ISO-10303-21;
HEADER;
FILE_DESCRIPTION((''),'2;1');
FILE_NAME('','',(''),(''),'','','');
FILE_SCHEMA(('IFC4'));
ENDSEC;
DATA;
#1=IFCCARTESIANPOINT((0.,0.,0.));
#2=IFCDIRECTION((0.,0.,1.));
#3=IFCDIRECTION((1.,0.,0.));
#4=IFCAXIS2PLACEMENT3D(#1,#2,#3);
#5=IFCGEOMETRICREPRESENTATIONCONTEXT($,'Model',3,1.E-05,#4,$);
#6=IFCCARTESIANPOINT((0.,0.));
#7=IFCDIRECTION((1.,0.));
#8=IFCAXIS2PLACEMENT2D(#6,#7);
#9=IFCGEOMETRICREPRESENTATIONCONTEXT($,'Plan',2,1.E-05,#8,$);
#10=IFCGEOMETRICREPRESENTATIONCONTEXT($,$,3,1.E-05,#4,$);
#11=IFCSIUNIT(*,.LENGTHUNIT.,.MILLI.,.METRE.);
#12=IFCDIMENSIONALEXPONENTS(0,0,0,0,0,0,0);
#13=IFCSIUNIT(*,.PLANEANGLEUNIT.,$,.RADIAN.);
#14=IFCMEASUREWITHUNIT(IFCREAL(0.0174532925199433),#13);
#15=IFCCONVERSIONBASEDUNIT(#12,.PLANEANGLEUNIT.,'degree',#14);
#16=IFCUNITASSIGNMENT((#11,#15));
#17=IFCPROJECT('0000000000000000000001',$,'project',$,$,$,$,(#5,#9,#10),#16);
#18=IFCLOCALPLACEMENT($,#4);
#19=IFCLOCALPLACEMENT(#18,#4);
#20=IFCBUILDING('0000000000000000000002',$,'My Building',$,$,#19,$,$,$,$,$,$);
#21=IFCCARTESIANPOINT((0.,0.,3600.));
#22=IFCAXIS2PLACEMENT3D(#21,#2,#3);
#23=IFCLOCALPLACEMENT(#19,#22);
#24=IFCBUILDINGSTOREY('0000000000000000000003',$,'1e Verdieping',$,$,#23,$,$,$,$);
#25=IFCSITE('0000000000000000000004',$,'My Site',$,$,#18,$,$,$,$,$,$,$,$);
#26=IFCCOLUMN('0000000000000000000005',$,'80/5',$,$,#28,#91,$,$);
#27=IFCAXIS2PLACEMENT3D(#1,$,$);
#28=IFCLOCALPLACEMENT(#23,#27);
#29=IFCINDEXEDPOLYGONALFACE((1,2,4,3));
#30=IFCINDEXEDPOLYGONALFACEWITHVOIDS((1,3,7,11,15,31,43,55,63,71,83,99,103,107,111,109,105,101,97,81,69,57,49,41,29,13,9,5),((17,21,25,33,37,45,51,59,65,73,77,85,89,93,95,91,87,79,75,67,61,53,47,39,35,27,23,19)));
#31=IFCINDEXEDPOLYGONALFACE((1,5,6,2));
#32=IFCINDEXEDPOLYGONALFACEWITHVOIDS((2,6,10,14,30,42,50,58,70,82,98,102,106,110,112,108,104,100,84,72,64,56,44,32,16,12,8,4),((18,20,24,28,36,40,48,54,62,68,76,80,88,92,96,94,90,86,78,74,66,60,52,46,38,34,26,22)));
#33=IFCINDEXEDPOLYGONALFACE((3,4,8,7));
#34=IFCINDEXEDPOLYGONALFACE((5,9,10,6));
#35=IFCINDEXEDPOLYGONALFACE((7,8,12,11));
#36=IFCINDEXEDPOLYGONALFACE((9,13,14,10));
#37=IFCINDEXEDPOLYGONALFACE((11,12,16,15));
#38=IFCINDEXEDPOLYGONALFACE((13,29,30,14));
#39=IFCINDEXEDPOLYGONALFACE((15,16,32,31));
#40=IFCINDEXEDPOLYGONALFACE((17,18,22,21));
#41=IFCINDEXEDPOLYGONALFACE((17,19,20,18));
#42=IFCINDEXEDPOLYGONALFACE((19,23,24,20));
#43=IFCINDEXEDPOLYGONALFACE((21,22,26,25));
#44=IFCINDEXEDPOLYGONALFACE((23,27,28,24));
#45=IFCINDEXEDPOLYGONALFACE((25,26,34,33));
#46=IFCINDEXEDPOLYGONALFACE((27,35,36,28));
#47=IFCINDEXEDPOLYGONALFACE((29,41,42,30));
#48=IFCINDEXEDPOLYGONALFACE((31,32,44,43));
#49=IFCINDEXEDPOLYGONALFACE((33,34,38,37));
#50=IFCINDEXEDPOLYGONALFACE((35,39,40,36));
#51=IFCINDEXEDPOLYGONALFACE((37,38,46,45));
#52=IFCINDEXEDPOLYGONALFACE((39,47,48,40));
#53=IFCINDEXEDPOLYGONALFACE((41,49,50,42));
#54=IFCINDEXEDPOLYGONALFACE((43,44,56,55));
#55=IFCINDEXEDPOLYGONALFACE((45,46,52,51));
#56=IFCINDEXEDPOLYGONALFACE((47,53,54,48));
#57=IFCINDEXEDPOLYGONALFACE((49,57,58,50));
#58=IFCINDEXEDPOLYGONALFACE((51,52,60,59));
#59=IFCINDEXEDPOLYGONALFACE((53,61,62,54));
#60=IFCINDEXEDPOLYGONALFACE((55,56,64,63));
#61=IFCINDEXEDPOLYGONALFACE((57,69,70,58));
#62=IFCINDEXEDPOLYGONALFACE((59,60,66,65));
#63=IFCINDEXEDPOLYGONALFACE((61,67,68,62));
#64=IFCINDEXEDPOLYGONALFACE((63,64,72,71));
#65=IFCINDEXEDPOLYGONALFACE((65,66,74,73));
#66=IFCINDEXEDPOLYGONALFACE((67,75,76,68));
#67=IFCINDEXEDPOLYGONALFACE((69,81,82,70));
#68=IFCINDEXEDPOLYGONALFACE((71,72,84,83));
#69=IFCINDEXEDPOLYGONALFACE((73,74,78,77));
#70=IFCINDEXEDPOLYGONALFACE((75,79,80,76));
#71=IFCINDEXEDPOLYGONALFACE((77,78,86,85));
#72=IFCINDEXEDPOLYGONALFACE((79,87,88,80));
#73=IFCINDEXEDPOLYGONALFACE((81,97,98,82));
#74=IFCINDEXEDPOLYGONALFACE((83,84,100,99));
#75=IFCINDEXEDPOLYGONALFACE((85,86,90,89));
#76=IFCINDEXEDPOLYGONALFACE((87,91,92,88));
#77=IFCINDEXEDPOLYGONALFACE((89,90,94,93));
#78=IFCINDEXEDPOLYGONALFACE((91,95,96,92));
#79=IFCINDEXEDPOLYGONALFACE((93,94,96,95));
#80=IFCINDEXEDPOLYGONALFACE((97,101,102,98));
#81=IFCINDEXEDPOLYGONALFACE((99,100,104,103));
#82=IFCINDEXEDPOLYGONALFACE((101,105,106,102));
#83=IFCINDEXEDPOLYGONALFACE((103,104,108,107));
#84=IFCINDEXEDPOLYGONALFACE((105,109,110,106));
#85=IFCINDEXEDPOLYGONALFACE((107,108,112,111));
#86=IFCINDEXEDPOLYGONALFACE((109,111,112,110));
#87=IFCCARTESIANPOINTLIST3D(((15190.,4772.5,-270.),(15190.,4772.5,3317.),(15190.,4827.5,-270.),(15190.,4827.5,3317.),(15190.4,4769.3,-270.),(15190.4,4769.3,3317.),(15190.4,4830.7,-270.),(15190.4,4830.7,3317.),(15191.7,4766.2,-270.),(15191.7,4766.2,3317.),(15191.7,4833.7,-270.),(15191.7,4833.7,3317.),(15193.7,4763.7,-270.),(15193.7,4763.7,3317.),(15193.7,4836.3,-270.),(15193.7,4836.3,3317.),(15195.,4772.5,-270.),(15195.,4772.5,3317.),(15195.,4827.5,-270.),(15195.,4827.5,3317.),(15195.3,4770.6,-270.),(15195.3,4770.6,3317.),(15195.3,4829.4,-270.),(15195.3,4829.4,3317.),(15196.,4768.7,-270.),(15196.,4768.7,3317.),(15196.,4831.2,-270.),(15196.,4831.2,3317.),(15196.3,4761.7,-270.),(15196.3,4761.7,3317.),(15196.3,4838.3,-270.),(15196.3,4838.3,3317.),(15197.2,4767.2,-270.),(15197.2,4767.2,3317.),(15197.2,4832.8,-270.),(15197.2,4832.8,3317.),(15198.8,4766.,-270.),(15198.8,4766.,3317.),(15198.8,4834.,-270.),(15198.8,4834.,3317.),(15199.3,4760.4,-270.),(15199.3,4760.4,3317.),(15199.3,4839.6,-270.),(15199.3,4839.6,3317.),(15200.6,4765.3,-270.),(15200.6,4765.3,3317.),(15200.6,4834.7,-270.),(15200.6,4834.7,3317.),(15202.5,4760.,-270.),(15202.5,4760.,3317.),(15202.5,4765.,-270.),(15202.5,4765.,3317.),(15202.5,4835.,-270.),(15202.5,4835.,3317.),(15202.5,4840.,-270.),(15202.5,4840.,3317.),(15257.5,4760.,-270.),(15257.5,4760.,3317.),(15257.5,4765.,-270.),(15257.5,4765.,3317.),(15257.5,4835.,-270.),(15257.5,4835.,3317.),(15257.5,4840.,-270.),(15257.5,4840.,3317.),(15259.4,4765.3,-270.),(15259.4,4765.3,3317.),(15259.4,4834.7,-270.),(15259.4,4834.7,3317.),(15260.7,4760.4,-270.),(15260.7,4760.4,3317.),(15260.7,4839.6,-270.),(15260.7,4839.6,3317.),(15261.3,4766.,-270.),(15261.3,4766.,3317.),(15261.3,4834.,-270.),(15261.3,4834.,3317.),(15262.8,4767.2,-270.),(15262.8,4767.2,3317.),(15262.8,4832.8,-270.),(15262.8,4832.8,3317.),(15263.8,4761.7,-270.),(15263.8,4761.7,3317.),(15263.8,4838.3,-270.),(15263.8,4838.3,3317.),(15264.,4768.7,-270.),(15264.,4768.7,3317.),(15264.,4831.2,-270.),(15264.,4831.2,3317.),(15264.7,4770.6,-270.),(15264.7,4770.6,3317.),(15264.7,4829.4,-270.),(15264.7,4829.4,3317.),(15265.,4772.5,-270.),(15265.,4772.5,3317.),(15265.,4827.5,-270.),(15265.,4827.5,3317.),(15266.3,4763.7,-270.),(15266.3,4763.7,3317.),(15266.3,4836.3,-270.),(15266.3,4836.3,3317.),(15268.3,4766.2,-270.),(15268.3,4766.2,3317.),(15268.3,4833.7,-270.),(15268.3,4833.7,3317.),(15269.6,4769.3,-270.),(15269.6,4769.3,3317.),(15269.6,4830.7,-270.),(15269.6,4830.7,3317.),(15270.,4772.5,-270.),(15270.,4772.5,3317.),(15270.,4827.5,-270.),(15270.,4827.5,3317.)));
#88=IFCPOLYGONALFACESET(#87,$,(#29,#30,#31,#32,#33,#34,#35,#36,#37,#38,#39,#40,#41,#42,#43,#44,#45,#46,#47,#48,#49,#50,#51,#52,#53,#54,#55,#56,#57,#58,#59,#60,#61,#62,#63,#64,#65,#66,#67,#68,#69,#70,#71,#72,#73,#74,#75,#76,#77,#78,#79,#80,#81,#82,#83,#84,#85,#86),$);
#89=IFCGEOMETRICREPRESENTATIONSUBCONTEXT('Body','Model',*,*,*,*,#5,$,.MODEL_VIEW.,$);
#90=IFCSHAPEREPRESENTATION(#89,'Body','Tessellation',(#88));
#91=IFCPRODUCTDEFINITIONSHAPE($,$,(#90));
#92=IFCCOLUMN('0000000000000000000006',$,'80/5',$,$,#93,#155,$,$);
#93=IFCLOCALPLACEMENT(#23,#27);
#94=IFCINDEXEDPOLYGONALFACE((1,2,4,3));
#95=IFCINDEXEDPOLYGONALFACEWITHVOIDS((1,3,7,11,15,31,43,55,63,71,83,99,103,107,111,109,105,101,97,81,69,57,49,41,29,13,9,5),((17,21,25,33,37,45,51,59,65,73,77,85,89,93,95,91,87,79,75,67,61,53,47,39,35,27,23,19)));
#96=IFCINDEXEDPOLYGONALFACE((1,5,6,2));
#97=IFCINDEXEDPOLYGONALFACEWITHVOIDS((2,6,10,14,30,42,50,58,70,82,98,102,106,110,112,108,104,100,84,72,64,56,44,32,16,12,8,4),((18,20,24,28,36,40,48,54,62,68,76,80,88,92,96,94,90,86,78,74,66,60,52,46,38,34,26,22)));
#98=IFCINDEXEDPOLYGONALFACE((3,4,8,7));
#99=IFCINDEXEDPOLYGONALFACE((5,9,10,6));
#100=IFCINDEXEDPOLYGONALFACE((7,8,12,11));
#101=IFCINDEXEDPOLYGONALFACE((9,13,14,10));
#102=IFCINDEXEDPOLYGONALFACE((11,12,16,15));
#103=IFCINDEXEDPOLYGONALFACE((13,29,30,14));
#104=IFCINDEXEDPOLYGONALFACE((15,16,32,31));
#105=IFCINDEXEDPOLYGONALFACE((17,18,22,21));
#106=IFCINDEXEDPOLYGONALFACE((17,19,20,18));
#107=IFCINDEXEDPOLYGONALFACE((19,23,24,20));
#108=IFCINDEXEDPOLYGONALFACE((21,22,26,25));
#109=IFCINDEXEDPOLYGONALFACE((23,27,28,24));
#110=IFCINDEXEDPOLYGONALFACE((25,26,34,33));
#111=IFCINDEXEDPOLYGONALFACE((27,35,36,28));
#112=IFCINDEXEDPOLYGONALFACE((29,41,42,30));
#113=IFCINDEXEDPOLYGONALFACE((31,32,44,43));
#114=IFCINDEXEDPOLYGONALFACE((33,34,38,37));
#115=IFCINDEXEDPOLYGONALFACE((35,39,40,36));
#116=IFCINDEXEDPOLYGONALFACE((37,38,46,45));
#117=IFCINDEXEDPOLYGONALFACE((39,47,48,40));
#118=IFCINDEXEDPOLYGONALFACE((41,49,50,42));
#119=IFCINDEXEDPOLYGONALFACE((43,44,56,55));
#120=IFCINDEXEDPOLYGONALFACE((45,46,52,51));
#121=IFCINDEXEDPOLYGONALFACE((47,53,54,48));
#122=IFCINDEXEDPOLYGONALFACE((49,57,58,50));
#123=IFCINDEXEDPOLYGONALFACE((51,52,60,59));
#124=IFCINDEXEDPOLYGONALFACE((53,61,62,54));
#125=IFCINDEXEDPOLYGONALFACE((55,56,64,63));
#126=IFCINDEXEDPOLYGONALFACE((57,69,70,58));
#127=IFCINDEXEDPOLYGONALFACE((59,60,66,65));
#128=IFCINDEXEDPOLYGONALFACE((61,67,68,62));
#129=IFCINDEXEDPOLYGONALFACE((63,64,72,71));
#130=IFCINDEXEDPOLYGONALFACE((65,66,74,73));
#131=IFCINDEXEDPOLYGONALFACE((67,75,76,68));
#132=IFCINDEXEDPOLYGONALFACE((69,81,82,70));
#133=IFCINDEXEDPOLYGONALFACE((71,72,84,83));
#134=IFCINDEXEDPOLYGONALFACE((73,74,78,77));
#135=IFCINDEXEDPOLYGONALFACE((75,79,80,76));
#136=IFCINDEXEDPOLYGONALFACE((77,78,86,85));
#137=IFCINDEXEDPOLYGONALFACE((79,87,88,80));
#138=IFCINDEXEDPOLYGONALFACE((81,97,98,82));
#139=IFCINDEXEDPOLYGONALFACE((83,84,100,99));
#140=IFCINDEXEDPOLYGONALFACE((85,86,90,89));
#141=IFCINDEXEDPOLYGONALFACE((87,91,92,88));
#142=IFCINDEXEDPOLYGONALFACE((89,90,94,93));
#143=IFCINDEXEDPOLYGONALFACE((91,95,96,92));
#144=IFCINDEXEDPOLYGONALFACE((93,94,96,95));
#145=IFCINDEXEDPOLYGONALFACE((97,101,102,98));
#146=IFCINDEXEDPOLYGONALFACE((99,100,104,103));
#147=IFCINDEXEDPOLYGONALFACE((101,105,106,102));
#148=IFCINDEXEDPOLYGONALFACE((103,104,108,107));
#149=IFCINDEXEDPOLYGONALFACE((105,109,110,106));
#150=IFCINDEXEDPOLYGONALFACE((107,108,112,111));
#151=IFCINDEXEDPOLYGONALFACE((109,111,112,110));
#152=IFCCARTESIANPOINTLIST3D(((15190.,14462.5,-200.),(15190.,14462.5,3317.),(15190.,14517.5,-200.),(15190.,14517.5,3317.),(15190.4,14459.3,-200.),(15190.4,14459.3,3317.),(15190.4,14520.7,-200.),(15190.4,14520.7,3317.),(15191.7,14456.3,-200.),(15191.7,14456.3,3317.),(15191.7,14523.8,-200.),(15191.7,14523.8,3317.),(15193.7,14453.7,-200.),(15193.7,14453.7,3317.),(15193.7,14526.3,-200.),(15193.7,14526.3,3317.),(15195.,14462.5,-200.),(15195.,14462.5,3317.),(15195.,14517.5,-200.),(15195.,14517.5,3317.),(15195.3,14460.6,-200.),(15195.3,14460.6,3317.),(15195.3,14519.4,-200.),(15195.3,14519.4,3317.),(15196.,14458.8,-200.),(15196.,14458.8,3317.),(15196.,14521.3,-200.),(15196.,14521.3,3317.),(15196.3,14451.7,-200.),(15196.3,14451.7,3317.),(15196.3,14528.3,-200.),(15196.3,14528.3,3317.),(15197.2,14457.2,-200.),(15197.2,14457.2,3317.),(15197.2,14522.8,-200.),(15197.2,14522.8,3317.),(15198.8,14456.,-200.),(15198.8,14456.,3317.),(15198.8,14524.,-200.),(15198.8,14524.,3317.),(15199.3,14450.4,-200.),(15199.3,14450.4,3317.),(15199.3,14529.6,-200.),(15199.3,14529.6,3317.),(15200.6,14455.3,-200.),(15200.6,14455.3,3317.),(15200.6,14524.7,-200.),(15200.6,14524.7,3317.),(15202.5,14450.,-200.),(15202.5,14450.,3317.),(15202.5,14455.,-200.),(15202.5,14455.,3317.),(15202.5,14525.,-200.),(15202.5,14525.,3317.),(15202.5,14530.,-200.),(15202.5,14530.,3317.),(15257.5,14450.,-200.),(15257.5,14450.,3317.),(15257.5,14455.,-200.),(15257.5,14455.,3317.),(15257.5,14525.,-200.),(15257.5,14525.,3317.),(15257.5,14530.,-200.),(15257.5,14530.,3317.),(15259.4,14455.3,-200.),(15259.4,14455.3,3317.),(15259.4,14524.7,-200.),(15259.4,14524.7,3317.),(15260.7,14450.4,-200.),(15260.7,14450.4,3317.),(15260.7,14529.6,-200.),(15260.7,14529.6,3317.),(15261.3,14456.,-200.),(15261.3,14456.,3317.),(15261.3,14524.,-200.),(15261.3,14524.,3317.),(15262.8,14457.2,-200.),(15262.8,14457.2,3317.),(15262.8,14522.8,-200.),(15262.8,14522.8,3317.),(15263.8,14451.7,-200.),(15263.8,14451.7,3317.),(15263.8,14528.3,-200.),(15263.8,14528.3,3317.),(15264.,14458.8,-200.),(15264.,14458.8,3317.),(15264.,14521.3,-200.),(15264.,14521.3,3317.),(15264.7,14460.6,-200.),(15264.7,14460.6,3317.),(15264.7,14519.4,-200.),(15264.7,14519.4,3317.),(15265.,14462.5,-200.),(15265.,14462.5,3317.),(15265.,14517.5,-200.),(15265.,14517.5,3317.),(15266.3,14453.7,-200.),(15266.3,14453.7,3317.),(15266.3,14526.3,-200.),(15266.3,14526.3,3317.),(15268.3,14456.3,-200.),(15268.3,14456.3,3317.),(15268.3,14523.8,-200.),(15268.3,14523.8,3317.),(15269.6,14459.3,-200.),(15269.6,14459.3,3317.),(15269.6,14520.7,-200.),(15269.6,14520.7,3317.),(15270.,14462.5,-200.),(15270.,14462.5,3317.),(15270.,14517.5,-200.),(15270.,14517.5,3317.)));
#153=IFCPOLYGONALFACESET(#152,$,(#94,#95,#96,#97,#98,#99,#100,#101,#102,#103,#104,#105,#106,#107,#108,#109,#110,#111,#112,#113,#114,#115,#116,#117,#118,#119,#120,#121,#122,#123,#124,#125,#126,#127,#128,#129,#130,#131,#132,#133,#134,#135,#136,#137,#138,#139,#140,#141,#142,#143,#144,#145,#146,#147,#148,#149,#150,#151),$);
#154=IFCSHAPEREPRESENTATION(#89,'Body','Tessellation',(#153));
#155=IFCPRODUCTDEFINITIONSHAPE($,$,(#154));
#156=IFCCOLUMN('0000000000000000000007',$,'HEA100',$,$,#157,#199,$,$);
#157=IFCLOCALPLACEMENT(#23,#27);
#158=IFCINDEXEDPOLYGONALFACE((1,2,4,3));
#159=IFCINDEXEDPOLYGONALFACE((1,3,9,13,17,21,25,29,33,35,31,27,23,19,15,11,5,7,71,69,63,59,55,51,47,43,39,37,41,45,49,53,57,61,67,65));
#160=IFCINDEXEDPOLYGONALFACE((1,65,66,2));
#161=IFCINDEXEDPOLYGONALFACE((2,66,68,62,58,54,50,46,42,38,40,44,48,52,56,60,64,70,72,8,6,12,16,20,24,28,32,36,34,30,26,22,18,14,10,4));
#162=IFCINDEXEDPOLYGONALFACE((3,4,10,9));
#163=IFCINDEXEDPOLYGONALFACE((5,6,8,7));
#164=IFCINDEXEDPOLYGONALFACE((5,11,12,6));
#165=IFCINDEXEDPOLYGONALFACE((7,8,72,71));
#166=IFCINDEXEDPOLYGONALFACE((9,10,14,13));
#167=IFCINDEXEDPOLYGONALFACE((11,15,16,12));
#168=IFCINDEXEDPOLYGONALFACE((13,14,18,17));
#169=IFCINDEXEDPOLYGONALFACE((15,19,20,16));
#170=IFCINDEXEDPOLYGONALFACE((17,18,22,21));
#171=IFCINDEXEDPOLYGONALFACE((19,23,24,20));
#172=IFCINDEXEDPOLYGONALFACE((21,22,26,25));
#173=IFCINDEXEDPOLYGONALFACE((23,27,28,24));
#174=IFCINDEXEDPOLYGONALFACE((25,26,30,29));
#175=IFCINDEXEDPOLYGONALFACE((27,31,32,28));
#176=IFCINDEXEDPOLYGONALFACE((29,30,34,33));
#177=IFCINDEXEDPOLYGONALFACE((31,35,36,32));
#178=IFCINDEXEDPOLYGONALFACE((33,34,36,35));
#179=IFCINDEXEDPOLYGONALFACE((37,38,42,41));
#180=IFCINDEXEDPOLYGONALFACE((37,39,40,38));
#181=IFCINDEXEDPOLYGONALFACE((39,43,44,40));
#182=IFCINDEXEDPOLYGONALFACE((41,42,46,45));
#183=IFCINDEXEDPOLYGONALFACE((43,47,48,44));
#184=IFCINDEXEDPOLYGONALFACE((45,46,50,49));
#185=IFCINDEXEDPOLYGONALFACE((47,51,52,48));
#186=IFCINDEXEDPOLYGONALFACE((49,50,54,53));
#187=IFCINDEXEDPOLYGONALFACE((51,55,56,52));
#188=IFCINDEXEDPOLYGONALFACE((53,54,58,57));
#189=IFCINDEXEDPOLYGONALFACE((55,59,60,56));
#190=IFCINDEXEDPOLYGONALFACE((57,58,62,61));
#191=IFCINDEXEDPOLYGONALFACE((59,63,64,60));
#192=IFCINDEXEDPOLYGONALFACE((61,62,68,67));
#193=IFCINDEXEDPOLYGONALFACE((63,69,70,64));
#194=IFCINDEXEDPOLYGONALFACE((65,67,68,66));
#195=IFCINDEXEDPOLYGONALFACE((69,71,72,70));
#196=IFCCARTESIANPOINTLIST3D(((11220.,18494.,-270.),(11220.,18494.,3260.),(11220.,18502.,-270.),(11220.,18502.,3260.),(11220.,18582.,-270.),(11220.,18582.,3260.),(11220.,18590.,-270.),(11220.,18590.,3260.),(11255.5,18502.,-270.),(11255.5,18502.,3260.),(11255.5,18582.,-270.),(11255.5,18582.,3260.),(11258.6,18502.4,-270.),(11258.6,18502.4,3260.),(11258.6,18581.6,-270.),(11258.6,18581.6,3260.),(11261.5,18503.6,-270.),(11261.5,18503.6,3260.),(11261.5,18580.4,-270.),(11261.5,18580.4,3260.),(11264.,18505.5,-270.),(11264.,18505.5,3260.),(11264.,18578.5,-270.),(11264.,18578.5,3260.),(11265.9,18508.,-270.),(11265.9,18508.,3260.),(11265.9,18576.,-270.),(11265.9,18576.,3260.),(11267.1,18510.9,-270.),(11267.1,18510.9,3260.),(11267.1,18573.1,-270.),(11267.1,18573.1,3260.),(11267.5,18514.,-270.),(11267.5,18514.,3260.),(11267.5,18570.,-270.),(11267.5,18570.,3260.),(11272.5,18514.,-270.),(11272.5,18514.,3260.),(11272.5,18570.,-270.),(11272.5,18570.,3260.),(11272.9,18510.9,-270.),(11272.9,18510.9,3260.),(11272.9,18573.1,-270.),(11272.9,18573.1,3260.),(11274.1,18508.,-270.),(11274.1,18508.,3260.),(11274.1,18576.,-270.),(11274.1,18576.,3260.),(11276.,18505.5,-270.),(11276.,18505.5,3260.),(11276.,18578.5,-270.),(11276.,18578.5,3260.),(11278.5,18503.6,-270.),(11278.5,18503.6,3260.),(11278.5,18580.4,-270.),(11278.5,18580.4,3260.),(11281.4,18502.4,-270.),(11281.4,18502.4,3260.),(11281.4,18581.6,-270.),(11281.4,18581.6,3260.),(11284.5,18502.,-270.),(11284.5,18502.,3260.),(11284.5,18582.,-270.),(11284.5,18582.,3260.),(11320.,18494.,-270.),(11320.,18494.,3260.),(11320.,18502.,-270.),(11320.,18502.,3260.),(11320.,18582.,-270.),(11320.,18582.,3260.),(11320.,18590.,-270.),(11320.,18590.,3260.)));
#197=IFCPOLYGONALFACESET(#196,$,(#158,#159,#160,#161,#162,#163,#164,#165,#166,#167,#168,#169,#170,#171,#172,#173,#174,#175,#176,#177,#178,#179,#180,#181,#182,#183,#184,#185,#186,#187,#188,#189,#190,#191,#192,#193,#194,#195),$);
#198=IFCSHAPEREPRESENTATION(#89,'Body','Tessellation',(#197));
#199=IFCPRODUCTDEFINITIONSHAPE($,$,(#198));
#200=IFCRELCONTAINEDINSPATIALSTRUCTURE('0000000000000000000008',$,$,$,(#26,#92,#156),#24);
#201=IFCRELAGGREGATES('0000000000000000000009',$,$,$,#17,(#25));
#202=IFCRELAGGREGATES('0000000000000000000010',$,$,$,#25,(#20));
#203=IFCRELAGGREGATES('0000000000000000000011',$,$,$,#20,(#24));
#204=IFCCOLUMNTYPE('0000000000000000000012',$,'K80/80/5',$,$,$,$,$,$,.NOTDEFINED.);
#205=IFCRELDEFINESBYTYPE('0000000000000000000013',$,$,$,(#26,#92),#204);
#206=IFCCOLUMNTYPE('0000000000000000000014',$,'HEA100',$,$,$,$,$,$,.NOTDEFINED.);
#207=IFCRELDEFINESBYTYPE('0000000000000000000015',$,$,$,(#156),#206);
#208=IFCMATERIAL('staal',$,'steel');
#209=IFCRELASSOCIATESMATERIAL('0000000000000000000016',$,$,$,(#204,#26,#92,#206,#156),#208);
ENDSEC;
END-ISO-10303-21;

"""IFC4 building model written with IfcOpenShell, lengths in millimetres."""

from ifc_helpers import new_model, entity, si_unit, converted_unit, frame, origin_with_axes, origin_2d_with_axis, place, context, subcontext, project, spatial, hollow_rectangle, i_section, extrude, material, material_profile, profile_set, profile_usage, type_object, element, save


model = new_model("IFC4")

# Units and contexts
model_context = context("Model", 3, precision=1e-05, world=origin_with_axes())
plan_context = context("Plan", 2, precision=1e-05, world=origin_2d_with_axis())
context_of_model = context(None, 3, precision=1e-05, world=origin_with_axes())
body_context = subcontext(model_context, "Body", "Model", "MODEL_VIEW")
ifc_project = project(units=[si_unit("LENGTHUNIT", "METRE", prefix="MILLI"), converted_unit("PLANEANGLEUNIT", "degree", entity("IfcReal", 0.0174532925199433), si_unit("PLANEANGLEUNIT", "RADIAN"), dimensions=[0, 0, 0, 0, 0, 0, 0])], contexts=[model_context, plan_context, context_of_model])

# Site, building, storey
site_placement = place(None, origin_with_axes())
site = spatial("IfcSite", under=ifc_project, at=site_placement, Name="My Site")
building_placement = place(site_placement, origin_with_axes())
building = spatial("IfcBuilding", under=site, at=building_placement, Name="My Building")
storey_placement = place(building_placement, frame((0.0, 0.0, 3600.0), z_axis=(0.0, 0.0, 1.0), x_axis=(1.0, 0.0, 0.0)))
storey = spatial("IfcBuildingStorey", under=building, at=storey_placement, Name="1e Verdieping")

# Columns
ifc_material = material(Name="staal", Category="steel")
ifc_material_profile_1 = material_profile(ifc_material, hollow_rectangle(XDim=80.0, YDim=80.0, WallThickness=5.0, InnerFilletRadius=7.5, OuterFilletRadius=12.5))
ifc_profile_set_1 = profile_set([ifc_material_profile_1], Name="K80/80/5")
column_type_1 = type_object("IfcColumnType", Name="K80/80/5", PredefinedType="NOTDEFINED", material=ifc_profile_set_1)
ifc_profile_usage_1 = profile_usage(ifc_profile_set_1)
column_1_placement = place(storey_placement, frame((15230.0, 4800.0, -270.0), z_axis=(0.0, 0.0, 1.0), x_axis=(1.0, 0.0, 0.0)))
element("IfcColumn", 1, at=column_1_placement, inside=storey, type_object=column_type_1, material=ifc_profile_usage_1, Name="80/5", context=body_context, shape_type="SweptSolid", body=[
    extrude(hollow_rectangle(XDim=80.0, YDim=80.0, WallThickness=5.0, InnerFilletRadius=7.5, OuterFilletRadius=12.5), origin_with_axes(), (0.0, 0.0, 1.0), 3587.0),
])
ifc_profile_usage_2 = profile_usage(ifc_profile_set_1)
column_2_placement = place(storey_placement, frame((15230.0, 14490.0, -200.0), z_axis=(0.0, 0.0, 1.0), x_axis=(1.0, 0.0, 0.0)))
element("IfcColumn", 2, at=column_2_placement, inside=storey, type_object=column_type_1, material=ifc_profile_usage_2, Name="80/5", context=body_context, shape_type="SweptSolid", body=[
    extrude(hollow_rectangle(XDim=80.0, YDim=80.0, WallThickness=5.0, InnerFilletRadius=7.5, OuterFilletRadius=12.5), origin_with_axes(), (0.0, 0.0, 1.0), 3517.0),
])
ifc_material_profile_2 = material_profile(ifc_material, i_section(OverallWidth=100.0, OverallDepth=96.0, WebThickness=5.0, FlangeThickness=8.0, FilletRadius=12.0))
ifc_profile_set_2 = profile_set([ifc_material_profile_2], Name="HEA100")
ifc_profile_usage_3 = profile_usage(ifc_profile_set_2)
column_type_2 = type_object("IfcColumnType", Name="HEA100", PredefinedType="NOTDEFINED", material=ifc_profile_set_2)
column_3_placement = place(storey_placement, frame((11270.0, 18542.0, -270.0), z_axis=(0.0, 0.0, 1.0), x_axis=(1.0, 0.0, 0.0)))
element("IfcColumn", 3, at=column_3_placement, inside=storey, type_object=column_type_2, material=ifc_profile_usage_3, Name="HEA100", context=body_context, shape_type="SweptSolid", body=[
    extrude(i_section(OverallWidth=100.0, OverallDepth=96.0, WebThickness=5.0, FlangeThickness=8.0, FilletRadius=12.0), origin_with_axes(), (0.0, 0.0, 1.0), 3530.0),
])

save(model, "model.ifc")
